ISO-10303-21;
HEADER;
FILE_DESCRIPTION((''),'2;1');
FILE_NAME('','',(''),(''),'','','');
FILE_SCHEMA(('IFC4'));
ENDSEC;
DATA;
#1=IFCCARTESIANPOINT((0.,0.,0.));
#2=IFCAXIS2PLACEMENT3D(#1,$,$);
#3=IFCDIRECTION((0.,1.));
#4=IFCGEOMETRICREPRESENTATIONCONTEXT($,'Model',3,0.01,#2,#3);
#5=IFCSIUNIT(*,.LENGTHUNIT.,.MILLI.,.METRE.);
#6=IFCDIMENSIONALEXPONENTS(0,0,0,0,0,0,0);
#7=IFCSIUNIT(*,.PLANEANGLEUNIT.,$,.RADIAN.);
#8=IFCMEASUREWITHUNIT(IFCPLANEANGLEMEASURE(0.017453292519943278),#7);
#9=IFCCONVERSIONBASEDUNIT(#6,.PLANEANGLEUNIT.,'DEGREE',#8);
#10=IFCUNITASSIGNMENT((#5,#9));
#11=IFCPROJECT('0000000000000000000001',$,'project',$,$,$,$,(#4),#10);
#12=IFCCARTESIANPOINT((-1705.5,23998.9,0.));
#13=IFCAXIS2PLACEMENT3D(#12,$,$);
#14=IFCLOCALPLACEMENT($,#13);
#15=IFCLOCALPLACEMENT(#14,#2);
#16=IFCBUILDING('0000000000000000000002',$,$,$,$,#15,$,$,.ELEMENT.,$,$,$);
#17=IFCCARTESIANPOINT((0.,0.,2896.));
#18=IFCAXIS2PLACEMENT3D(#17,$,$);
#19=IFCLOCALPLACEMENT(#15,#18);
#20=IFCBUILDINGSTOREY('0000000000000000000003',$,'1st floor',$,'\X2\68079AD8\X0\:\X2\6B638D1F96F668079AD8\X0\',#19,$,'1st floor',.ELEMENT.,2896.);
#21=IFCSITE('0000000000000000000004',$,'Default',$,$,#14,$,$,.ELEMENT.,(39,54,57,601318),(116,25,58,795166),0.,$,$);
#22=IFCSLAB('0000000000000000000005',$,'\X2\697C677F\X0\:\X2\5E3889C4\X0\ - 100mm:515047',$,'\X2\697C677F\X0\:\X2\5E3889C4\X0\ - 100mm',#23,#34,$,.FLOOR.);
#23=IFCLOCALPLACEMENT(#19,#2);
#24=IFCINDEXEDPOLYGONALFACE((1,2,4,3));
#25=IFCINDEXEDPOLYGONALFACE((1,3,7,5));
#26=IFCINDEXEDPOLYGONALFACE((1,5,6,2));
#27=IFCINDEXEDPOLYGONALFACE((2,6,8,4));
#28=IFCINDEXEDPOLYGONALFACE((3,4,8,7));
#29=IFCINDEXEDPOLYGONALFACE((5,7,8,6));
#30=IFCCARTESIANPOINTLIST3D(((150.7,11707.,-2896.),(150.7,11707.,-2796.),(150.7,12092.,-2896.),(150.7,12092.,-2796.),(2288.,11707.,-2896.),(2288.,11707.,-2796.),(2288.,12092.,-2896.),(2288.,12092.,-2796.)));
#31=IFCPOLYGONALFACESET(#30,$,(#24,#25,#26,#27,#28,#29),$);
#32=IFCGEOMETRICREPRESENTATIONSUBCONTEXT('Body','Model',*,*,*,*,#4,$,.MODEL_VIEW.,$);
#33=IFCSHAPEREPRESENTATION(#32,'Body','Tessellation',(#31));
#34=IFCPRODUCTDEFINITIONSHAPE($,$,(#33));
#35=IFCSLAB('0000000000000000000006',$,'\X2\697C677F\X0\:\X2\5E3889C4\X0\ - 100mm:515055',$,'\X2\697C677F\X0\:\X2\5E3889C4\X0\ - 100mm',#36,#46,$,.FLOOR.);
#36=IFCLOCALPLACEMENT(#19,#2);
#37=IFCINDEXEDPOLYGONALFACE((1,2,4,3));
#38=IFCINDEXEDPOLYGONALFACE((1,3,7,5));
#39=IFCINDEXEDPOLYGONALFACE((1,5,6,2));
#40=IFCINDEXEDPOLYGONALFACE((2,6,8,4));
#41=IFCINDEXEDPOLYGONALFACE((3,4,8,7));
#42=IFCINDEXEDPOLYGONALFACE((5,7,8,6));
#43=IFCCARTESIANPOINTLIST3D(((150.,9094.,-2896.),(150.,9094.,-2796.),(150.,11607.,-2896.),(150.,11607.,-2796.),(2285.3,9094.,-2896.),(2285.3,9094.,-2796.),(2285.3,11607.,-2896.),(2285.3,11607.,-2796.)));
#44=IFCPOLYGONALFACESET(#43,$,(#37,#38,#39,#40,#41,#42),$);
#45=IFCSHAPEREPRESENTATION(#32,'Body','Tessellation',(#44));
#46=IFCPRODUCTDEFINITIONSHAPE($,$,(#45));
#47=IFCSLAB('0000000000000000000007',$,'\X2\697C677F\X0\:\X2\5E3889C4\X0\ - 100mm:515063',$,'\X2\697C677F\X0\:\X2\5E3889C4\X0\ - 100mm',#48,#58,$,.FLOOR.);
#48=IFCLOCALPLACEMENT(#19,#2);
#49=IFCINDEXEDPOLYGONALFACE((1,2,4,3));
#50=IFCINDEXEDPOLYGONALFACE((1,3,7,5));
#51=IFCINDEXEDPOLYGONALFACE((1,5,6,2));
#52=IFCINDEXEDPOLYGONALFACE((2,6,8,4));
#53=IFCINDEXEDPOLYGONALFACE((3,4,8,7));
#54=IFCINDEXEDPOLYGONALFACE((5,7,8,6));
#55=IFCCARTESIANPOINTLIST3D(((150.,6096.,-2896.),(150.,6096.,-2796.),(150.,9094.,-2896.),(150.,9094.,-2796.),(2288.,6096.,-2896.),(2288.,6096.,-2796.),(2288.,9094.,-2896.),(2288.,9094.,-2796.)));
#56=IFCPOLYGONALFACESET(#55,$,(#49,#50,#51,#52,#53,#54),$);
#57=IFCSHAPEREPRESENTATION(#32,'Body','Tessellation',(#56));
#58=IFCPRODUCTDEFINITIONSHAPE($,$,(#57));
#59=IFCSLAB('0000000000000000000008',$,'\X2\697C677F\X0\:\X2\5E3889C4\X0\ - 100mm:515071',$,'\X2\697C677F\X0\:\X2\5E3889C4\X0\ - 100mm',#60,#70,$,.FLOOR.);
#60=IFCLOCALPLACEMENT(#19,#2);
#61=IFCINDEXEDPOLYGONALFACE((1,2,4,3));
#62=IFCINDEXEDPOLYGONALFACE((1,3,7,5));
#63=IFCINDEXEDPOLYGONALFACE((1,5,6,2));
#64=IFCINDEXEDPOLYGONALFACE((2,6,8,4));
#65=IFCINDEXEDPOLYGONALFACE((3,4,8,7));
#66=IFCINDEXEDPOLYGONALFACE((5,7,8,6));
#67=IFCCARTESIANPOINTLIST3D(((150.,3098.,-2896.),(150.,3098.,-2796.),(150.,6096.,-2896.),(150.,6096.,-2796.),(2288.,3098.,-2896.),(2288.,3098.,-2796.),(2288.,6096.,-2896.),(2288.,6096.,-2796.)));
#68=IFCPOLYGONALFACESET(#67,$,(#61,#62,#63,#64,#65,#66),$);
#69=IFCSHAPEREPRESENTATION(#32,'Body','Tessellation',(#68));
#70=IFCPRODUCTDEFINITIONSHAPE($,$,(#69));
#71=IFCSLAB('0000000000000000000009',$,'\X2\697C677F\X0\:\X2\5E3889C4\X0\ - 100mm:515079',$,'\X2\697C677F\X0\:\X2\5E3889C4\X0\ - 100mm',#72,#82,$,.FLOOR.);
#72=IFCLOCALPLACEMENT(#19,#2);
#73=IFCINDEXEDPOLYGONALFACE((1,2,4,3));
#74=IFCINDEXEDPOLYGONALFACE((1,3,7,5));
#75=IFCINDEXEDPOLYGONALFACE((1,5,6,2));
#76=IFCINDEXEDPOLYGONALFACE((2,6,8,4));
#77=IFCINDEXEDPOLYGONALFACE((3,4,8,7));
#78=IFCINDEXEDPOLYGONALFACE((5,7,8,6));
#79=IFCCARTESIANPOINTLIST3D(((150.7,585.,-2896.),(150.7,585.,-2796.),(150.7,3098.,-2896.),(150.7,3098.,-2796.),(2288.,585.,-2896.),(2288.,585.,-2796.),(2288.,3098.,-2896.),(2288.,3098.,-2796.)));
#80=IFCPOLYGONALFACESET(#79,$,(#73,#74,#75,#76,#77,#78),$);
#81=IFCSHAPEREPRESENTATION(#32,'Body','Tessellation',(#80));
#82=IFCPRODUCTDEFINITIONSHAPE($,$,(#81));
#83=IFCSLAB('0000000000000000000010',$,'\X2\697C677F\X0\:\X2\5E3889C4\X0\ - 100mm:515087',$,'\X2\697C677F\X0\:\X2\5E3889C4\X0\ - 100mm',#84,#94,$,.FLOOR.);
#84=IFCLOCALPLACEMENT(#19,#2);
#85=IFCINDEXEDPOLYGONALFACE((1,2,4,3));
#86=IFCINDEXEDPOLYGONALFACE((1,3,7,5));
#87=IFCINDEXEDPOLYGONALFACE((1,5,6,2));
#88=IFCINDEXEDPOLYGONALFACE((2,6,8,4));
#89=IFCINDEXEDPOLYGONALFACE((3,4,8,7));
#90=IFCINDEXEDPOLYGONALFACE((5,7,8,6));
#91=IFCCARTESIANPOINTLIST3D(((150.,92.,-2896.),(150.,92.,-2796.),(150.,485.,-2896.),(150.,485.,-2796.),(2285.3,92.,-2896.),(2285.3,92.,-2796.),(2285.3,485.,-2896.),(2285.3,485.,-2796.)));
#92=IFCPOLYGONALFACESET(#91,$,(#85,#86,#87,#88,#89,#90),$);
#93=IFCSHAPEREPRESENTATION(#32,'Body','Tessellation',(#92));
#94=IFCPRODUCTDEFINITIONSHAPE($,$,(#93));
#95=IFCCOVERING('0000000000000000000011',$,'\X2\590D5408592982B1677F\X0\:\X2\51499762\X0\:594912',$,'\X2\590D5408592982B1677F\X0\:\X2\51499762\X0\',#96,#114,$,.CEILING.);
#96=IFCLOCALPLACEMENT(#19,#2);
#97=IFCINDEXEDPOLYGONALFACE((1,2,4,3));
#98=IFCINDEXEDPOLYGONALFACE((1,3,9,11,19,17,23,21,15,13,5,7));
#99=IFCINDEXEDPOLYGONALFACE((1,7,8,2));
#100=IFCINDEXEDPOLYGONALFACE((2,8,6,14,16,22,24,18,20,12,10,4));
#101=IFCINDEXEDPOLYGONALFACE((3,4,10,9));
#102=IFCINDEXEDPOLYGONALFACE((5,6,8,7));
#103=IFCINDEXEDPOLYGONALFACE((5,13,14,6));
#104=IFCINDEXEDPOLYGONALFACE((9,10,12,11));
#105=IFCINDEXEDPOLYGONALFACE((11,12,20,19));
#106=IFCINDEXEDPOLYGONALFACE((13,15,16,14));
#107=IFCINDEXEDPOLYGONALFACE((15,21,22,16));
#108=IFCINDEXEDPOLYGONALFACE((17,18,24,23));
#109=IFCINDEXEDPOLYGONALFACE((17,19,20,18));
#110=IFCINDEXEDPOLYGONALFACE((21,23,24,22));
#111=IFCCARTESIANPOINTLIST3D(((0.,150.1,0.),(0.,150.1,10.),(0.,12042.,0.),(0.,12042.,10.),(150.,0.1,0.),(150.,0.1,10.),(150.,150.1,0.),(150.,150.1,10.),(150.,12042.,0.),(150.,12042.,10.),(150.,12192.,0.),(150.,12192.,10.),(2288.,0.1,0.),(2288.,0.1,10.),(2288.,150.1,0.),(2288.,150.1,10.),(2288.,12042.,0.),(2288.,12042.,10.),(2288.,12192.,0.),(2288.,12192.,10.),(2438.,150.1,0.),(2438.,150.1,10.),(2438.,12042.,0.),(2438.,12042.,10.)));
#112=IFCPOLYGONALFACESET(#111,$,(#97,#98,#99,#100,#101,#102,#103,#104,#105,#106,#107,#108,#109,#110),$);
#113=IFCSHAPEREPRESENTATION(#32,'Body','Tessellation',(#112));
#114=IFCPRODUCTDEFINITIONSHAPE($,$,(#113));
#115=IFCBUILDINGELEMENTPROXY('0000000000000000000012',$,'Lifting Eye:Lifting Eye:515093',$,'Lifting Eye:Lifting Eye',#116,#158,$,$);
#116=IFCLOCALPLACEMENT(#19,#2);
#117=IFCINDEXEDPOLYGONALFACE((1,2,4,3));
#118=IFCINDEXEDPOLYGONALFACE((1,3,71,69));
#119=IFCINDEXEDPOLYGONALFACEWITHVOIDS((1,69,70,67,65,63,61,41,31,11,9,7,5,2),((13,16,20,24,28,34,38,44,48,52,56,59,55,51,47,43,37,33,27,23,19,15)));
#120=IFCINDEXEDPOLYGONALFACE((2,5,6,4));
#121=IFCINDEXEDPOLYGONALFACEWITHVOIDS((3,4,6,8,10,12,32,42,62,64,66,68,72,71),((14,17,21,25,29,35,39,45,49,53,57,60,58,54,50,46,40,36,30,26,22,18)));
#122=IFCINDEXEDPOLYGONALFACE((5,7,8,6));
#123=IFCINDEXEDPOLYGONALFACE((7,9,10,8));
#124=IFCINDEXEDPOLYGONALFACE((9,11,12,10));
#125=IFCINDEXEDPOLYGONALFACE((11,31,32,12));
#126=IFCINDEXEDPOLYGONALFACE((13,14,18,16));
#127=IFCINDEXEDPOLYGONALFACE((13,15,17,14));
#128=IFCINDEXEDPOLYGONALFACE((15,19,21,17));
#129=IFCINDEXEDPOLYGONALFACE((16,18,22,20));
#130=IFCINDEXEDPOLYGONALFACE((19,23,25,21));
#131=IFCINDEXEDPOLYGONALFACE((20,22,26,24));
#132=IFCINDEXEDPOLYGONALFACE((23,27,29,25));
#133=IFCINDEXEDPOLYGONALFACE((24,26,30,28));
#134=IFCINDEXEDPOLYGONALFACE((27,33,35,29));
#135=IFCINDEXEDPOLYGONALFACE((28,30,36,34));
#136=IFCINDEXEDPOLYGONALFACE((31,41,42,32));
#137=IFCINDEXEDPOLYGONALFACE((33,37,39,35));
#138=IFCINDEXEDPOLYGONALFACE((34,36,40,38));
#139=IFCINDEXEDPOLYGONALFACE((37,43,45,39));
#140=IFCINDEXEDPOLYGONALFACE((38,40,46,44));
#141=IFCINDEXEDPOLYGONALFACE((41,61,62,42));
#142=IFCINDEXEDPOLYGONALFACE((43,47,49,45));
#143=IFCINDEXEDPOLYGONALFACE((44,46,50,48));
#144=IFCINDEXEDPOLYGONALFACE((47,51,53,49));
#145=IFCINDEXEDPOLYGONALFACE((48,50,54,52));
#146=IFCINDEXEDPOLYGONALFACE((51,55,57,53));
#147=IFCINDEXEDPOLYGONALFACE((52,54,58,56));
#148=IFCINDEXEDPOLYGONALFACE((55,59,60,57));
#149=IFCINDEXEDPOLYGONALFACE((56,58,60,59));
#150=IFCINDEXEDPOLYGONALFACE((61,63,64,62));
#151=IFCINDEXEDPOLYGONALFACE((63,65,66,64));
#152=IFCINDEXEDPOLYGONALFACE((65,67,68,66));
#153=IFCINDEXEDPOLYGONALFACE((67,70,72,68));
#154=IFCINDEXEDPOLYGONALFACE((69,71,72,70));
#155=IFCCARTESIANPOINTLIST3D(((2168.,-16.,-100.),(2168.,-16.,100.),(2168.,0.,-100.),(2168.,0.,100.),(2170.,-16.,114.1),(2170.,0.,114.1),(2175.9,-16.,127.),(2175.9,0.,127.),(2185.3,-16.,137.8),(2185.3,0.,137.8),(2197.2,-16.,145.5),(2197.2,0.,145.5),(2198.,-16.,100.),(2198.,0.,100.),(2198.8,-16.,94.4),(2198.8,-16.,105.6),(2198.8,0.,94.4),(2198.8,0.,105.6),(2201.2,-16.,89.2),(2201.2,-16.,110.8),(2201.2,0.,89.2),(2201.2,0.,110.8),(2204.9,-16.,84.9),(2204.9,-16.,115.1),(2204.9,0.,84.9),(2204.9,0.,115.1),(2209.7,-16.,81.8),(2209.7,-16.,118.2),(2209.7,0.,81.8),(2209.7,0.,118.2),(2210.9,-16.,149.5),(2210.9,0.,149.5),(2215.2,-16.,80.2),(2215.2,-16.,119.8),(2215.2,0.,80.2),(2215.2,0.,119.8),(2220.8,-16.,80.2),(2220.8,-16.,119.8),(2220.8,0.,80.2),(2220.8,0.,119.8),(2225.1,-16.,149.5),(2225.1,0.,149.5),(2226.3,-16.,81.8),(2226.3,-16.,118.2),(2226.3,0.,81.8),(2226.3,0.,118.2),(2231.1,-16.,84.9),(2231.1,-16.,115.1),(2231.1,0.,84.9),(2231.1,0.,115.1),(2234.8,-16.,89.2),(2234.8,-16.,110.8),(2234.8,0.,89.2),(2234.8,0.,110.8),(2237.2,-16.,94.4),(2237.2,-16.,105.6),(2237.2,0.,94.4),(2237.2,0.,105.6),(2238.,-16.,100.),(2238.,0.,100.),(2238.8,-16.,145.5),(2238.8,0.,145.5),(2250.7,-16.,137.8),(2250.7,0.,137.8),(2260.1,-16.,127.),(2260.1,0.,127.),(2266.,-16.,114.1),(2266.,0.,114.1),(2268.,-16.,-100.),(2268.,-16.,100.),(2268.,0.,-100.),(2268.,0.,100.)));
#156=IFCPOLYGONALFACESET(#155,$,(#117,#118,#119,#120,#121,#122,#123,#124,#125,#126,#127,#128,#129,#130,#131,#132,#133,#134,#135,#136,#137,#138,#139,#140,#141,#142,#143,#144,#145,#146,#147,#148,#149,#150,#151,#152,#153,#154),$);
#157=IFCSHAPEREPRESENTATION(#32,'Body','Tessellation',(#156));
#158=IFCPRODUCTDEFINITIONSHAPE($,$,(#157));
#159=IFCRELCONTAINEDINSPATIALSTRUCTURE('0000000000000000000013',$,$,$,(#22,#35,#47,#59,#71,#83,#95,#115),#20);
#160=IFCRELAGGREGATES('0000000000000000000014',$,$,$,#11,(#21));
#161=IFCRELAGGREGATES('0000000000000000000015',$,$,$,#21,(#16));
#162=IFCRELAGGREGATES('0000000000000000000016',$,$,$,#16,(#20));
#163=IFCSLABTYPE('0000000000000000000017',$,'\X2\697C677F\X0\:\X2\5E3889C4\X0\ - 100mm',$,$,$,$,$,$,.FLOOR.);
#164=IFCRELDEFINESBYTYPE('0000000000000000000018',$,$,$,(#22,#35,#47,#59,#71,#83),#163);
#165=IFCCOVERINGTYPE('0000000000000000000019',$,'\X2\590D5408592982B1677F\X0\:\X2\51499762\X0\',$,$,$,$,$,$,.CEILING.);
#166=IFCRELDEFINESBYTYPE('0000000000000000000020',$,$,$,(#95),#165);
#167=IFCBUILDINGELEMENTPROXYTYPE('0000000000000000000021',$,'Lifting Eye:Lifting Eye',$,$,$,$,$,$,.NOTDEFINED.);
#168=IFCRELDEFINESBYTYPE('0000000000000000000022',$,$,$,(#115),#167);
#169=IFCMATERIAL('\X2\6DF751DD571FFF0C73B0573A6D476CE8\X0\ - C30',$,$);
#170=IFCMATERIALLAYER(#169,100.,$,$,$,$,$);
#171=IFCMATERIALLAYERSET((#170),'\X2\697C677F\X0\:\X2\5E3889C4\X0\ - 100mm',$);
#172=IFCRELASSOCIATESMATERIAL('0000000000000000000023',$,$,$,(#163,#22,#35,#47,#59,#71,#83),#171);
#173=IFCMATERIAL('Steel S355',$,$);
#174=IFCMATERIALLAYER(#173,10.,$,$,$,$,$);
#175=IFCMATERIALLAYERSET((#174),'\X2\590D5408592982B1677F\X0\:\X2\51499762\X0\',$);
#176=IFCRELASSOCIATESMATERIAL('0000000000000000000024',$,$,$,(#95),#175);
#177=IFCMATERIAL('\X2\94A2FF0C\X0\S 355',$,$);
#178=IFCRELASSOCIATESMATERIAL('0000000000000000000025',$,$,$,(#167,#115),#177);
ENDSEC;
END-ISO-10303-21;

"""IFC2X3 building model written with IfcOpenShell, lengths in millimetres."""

from ifc_helpers import new_model, entity, si_unit, converted_unit, direction, frame, frame_2d, origin, origin_2d_with_axis, place, context, subcontext, project, spatial, polyline, circle_curve, parameter, trimmed, segment, composite_curve, rectangle, outline, extrude, source, transform, mapped, material, layer, layer_set, layer_usage, type_object, type_shapes, element, save


model = new_model("IFC2X3")

# Units and contexts
model_context = context("Model", 3, precision=0.01, world=origin(), true_north=direction((0.0, 1.0)))
body_context = subcontext(model_context, "Body", "Model", "MODEL_VIEW")
ifc_project = project(units=[si_unit("LENGTHUNIT", "METRE", prefix="MILLI"), converted_unit("PLANEANGLEUNIT", "DEGREE", entity("IfcPlaneAngleMeasure", 0.017453292519943278), si_unit("PLANEANGLEUNIT", "RADIAN"), dimensions=[0, 0, 0, 0, 0, 0, 0])], contexts=[model_context])

# Site, building, storey
site_placement = place(None, frame((-1705.5, 23998.9, 0.0)))
site = spatial("IfcSite", under=ifc_project, at=site_placement, Name="Default", CompositionType="ELEMENT", RefLatitude=(39, 54, 57, 601318), RefLongitude=(116, 25, 58, 795166), RefElevation=0.0)
building_placement = place(site_placement, origin())
building = spatial("IfcBuilding", under=site, at=building_placement, CompositionType="ELEMENT")
storey_placement = place(building_placement, frame((0.0, 0.0, 2896.0)))
storey = spatial("IfcBuildingStorey", under=building, at=storey_placement, Name="1st floor", ObjectType="标高:正负零标高", LongName="1st floor", CompositionType="ELEMENT", Elevation=2896.0)

# Shared definitions
ifc_material_1 = material(Name="Steel S355")

# Slabs
ifc_material_2 = material(Name="混凝土，现场浇注 - C30")
ifc_layer_1 = layer(ifc_material_2, 100.0)
ifc_layer_set_1 = layer_set([ifc_layer_1], Name="楼板:常规 - 100mm")
ifc_layer_usage_1 = layer_usage(ifc_layer_set_1, "AXIS3", "POSITIVE", 0.0)
slab_type = type_object("IfcSlabType", Name="楼板:常规 - 100mm", PredefinedType="FLOOR", material=ifc_layer_set_1)
slab_1_placement = place(storey_placement, origin())
element("IfcSlab", 1, at=slab_1_placement, inside=storey, type_object=slab_type, material=ifc_layer_usage_1, Name="楼板:常规 - 100mm:515047", ObjectType="楼板:常规 - 100mm", PredefinedType="FLOOR", context=body_context, shape_type="SweptSolid", body=[
    extrude(rectangle(XDim=385.0, YDim=2137.3, at=origin_2d_with_axis()), frame((1219.3, 11899.5, -2796.0), z_axis=(0.0, 0.0, -1.0), x_axis=(0.0, 1.0, 0.0)), (0.0, 0.0, 1.0), 100.0),
])
ifc_layer_usage_2 = layer_usage(ifc_layer_set_1, "AXIS3", "POSITIVE", 0.0)
slab_2_placement = place(storey_placement, origin())
element("IfcSlab", 2, at=slab_2_placement, inside=storey, type_object=slab_type, material=ifc_layer_usage_2, Name="楼板:常规 - 100mm:515055", ObjectType="楼板:常规 - 100mm", PredefinedType="FLOOR", context=body_context, shape_type="SweptSolid", body=[
    extrude(rectangle(XDim=2513.0, YDim=2135.3, at=frame_2d((0.0, 0.0), x_axis=(1.0, 0.0))), frame((1217.6, 10350.5, -2796.0), z_axis=(0.0, 0.0, -1.0), x_axis=(0.0, 1.0, 0.0)), (0.0, 0.0, 1.0), 100.0),
])
ifc_layer_usage_3 = layer_usage(ifc_layer_set_1, "AXIS3", "POSITIVE", 0.0)
slab_3_placement = place(storey_placement, origin())
element("IfcSlab", 3, at=slab_3_placement, inside=storey, type_object=slab_type, material=ifc_layer_usage_3, Name="楼板:常规 - 100mm:515063", ObjectType="楼板:常规 - 100mm", PredefinedType="FLOOR", context=body_context, shape_type="SweptSolid", body=[
    extrude(rectangle(XDim=2998.0, YDim=2138.0, at=origin_2d_with_axis()), frame((1219.0, 7595.0, -2796.0), z_axis=(0.0, 0.0, -1.0), x_axis=(0.0, 1.0, 0.0)), (0.0, 0.0, 1.0), 100.0),
])
ifc_layer_usage_4 = layer_usage(ifc_layer_set_1, "AXIS3", "POSITIVE", 0.0)
slab_4_placement = place(storey_placement, origin())
element("IfcSlab", 4, at=slab_4_placement, inside=storey, type_object=slab_type, material=ifc_layer_usage_4, Name="楼板:常规 - 100mm:515071", ObjectType="楼板:常规 - 100mm", PredefinedType="FLOOR", context=body_context, shape_type="SweptSolid", body=[
    extrude(rectangle(XDim=2998.0, YDim=2138.0, at=frame_2d((0.0, 0.0), x_axis=(1.0, 0.0))), frame((1219.0, 4597.0, -2796.0), z_axis=(0.0, 0.0, -1.0), x_axis=(0.0, 1.0, 0.0)), (0.0, 0.0, 1.0), 100.0),
])
ifc_layer_usage_5 = layer_usage(ifc_layer_set_1, "AXIS3", "POSITIVE", 0.0)
slab_5_placement = place(storey_placement, origin())
element("IfcSlab", 5, at=slab_5_placement, inside=storey, type_object=slab_type, material=ifc_layer_usage_5, Name="楼板:常规 - 100mm:515079", ObjectType="楼板:常规 - 100mm", PredefinedType="FLOOR", context=body_context, shape_type="SweptSolid", body=[
    extrude(rectangle(XDim=2513.0, YDim=2137.3, at=origin_2d_with_axis()), frame((1219.3, 1841.5, -2796.0), z_axis=(0.0, 0.0, -1.0), x_axis=(0.0, 1.0, 0.0)), (0.0, 0.0, 1.0), 100.0),
])
ifc_layer_usage_6 = layer_usage(ifc_layer_set_1, "AXIS3", "POSITIVE", 0.0)
slab_6_placement = place(storey_placement, origin())
element("IfcSlab", 6, at=slab_6_placement, inside=storey, type_object=slab_type, material=ifc_layer_usage_6, Name="楼板:常规 - 100mm:515087", ObjectType="楼板:常规 - 100mm", PredefinedType="FLOOR", context=body_context, shape_type="SweptSolid", body=[
    extrude(rectangle(XDim=393.0, YDim=2135.3, at=frame_2d((0.0, 0.0), x_axis=(1.0, 0.0))), frame((1217.7, 288.5, -2796.0), z_axis=(0.0, 0.0, -1.0), x_axis=(0.0, 1.0, 0.0)), (0.0, 0.0, 1.0), 100.0),
])

# Covering
ifc_layer_2 = layer(ifc_material_1, 10.0)
ifc_layer_set_2 = layer_set([ifc_layer_2], Name="复合天花板:光面")
ifc_layer_usage_7 = layer_usage(ifc_layer_set_2, "AXIS3", "NEGATIVE", 10.0)
covering_type = type_object("IfcCoveringType", Name="复合天花板:光面", PredefinedType="CEILING")
covering_placement = place(storey_placement, origin())
element("IfcCovering", 7, at=covering_placement, inside=storey, type_object=covering_type, material=ifc_layer_usage_7, Name="复合天花板:光面:594912", ObjectType="复合天花板:光面", PredefinedType="CEILING", context=body_context, shape_type="SweptSolid", body=[
    extrude(outline(polyline([(5946.0, -1069.0), (6096.0, -1069.0), (6096.0, 1069.0), (5945.9, 1069.0), (5945.9, 1219.0), (-5946.0, 1219.0), (-5946.0, 1069.0), (-6096.0, 1069.0), (-6096.0, -1069.0), (-5946.0, -1069.0), (-5946.0, -1219.0), (5946.0, -1219.0), (5946.0, -1069.0)])), frame((1219.0, 6096.0, 0.0), z_axis=(0.0, 0.0, 1.0), x_axis=(0.0, 1.0, 0.0)), (0.0, 0.0, 1.0), 10.0),
])

# Building element proxy
ifc_material_3 = material(Name="钢，S 355")
building_element_proxy_type_1 = type_object("IfcBuildingElementProxyType", Name="Lifting Eye:Lifting Eye", PredefinedType="NOTDEFINED", material=ifc_material_3)
shared_shape_1 = source(origin(), body_context, "Body", "SweptSolid", [
    extrude(outline(composite_curve([segment(polyline([(-100.0, -50.0), (100.0, -50.0)]), True, "CONTINUOUS"), segment(polyline([(100.0, -50.0), (100.0, 50.0)]), True, "CONTINUOUS"), segment(polyline([(100.0, 50.0), (-100.0, 50.0)]), True, "CONTINUOUS"), segment(trimmed(circle_curve(frame_2d((-100.0, 0.0), x_axis=(0.0, -1.0)), 50.0), [parameter(180.0)], [parameter(0.0)], True, "PARAMETER"), True, "CONTINUOUS")], self_intersect=False), holes=[composite_curve([segment(trimmed(circle_curve(frame_2d((-100.0, 0.0), x_axis=(0.0, -1.0)), 20.0), [parameter(180.0)], [parameter(360.0)], True, "PARAMETER"), False, "CONTINUOUS"), segment(trimmed(circle_curve(frame_2d((-100.0, 0.0), x_axis=(0.0, -1.0)), 20.0), [parameter(0.0)], [parameter(180.0)], True, "PARAMETER"), False, "CONTINUOUS")], self_intersect=False)]), frame((0.0, 17.0, -17.0), z_axis=(0.0, 1.0, 0.0), x_axis=(0.0, 0.0, -1.0)), (0.0, 0.0, 1.0), 16.0),
])
type_shapes(building_element_proxy_type_1, [shared_shape_1])
for number, where, name in (
    (8, (2218.0, -33.0, 17.0), "Lifting Eye:Lifting Eye:515093"),
):
    element("IfcBuildingElementProxy", number, at=place(storey_placement, frame(where)), inside=storey, type_object=building_element_proxy_type_1, material=ifc_material_3, Name=name, ObjectType="Lifting Eye:Lifting Eye", context=body_context, shape_type="MappedRepresentation", body=[
        mapped(shared_shape_1, transform((0.0, 0.0, 0.0), scale=1.0)),
    ])

save(model, "model.ifc")
